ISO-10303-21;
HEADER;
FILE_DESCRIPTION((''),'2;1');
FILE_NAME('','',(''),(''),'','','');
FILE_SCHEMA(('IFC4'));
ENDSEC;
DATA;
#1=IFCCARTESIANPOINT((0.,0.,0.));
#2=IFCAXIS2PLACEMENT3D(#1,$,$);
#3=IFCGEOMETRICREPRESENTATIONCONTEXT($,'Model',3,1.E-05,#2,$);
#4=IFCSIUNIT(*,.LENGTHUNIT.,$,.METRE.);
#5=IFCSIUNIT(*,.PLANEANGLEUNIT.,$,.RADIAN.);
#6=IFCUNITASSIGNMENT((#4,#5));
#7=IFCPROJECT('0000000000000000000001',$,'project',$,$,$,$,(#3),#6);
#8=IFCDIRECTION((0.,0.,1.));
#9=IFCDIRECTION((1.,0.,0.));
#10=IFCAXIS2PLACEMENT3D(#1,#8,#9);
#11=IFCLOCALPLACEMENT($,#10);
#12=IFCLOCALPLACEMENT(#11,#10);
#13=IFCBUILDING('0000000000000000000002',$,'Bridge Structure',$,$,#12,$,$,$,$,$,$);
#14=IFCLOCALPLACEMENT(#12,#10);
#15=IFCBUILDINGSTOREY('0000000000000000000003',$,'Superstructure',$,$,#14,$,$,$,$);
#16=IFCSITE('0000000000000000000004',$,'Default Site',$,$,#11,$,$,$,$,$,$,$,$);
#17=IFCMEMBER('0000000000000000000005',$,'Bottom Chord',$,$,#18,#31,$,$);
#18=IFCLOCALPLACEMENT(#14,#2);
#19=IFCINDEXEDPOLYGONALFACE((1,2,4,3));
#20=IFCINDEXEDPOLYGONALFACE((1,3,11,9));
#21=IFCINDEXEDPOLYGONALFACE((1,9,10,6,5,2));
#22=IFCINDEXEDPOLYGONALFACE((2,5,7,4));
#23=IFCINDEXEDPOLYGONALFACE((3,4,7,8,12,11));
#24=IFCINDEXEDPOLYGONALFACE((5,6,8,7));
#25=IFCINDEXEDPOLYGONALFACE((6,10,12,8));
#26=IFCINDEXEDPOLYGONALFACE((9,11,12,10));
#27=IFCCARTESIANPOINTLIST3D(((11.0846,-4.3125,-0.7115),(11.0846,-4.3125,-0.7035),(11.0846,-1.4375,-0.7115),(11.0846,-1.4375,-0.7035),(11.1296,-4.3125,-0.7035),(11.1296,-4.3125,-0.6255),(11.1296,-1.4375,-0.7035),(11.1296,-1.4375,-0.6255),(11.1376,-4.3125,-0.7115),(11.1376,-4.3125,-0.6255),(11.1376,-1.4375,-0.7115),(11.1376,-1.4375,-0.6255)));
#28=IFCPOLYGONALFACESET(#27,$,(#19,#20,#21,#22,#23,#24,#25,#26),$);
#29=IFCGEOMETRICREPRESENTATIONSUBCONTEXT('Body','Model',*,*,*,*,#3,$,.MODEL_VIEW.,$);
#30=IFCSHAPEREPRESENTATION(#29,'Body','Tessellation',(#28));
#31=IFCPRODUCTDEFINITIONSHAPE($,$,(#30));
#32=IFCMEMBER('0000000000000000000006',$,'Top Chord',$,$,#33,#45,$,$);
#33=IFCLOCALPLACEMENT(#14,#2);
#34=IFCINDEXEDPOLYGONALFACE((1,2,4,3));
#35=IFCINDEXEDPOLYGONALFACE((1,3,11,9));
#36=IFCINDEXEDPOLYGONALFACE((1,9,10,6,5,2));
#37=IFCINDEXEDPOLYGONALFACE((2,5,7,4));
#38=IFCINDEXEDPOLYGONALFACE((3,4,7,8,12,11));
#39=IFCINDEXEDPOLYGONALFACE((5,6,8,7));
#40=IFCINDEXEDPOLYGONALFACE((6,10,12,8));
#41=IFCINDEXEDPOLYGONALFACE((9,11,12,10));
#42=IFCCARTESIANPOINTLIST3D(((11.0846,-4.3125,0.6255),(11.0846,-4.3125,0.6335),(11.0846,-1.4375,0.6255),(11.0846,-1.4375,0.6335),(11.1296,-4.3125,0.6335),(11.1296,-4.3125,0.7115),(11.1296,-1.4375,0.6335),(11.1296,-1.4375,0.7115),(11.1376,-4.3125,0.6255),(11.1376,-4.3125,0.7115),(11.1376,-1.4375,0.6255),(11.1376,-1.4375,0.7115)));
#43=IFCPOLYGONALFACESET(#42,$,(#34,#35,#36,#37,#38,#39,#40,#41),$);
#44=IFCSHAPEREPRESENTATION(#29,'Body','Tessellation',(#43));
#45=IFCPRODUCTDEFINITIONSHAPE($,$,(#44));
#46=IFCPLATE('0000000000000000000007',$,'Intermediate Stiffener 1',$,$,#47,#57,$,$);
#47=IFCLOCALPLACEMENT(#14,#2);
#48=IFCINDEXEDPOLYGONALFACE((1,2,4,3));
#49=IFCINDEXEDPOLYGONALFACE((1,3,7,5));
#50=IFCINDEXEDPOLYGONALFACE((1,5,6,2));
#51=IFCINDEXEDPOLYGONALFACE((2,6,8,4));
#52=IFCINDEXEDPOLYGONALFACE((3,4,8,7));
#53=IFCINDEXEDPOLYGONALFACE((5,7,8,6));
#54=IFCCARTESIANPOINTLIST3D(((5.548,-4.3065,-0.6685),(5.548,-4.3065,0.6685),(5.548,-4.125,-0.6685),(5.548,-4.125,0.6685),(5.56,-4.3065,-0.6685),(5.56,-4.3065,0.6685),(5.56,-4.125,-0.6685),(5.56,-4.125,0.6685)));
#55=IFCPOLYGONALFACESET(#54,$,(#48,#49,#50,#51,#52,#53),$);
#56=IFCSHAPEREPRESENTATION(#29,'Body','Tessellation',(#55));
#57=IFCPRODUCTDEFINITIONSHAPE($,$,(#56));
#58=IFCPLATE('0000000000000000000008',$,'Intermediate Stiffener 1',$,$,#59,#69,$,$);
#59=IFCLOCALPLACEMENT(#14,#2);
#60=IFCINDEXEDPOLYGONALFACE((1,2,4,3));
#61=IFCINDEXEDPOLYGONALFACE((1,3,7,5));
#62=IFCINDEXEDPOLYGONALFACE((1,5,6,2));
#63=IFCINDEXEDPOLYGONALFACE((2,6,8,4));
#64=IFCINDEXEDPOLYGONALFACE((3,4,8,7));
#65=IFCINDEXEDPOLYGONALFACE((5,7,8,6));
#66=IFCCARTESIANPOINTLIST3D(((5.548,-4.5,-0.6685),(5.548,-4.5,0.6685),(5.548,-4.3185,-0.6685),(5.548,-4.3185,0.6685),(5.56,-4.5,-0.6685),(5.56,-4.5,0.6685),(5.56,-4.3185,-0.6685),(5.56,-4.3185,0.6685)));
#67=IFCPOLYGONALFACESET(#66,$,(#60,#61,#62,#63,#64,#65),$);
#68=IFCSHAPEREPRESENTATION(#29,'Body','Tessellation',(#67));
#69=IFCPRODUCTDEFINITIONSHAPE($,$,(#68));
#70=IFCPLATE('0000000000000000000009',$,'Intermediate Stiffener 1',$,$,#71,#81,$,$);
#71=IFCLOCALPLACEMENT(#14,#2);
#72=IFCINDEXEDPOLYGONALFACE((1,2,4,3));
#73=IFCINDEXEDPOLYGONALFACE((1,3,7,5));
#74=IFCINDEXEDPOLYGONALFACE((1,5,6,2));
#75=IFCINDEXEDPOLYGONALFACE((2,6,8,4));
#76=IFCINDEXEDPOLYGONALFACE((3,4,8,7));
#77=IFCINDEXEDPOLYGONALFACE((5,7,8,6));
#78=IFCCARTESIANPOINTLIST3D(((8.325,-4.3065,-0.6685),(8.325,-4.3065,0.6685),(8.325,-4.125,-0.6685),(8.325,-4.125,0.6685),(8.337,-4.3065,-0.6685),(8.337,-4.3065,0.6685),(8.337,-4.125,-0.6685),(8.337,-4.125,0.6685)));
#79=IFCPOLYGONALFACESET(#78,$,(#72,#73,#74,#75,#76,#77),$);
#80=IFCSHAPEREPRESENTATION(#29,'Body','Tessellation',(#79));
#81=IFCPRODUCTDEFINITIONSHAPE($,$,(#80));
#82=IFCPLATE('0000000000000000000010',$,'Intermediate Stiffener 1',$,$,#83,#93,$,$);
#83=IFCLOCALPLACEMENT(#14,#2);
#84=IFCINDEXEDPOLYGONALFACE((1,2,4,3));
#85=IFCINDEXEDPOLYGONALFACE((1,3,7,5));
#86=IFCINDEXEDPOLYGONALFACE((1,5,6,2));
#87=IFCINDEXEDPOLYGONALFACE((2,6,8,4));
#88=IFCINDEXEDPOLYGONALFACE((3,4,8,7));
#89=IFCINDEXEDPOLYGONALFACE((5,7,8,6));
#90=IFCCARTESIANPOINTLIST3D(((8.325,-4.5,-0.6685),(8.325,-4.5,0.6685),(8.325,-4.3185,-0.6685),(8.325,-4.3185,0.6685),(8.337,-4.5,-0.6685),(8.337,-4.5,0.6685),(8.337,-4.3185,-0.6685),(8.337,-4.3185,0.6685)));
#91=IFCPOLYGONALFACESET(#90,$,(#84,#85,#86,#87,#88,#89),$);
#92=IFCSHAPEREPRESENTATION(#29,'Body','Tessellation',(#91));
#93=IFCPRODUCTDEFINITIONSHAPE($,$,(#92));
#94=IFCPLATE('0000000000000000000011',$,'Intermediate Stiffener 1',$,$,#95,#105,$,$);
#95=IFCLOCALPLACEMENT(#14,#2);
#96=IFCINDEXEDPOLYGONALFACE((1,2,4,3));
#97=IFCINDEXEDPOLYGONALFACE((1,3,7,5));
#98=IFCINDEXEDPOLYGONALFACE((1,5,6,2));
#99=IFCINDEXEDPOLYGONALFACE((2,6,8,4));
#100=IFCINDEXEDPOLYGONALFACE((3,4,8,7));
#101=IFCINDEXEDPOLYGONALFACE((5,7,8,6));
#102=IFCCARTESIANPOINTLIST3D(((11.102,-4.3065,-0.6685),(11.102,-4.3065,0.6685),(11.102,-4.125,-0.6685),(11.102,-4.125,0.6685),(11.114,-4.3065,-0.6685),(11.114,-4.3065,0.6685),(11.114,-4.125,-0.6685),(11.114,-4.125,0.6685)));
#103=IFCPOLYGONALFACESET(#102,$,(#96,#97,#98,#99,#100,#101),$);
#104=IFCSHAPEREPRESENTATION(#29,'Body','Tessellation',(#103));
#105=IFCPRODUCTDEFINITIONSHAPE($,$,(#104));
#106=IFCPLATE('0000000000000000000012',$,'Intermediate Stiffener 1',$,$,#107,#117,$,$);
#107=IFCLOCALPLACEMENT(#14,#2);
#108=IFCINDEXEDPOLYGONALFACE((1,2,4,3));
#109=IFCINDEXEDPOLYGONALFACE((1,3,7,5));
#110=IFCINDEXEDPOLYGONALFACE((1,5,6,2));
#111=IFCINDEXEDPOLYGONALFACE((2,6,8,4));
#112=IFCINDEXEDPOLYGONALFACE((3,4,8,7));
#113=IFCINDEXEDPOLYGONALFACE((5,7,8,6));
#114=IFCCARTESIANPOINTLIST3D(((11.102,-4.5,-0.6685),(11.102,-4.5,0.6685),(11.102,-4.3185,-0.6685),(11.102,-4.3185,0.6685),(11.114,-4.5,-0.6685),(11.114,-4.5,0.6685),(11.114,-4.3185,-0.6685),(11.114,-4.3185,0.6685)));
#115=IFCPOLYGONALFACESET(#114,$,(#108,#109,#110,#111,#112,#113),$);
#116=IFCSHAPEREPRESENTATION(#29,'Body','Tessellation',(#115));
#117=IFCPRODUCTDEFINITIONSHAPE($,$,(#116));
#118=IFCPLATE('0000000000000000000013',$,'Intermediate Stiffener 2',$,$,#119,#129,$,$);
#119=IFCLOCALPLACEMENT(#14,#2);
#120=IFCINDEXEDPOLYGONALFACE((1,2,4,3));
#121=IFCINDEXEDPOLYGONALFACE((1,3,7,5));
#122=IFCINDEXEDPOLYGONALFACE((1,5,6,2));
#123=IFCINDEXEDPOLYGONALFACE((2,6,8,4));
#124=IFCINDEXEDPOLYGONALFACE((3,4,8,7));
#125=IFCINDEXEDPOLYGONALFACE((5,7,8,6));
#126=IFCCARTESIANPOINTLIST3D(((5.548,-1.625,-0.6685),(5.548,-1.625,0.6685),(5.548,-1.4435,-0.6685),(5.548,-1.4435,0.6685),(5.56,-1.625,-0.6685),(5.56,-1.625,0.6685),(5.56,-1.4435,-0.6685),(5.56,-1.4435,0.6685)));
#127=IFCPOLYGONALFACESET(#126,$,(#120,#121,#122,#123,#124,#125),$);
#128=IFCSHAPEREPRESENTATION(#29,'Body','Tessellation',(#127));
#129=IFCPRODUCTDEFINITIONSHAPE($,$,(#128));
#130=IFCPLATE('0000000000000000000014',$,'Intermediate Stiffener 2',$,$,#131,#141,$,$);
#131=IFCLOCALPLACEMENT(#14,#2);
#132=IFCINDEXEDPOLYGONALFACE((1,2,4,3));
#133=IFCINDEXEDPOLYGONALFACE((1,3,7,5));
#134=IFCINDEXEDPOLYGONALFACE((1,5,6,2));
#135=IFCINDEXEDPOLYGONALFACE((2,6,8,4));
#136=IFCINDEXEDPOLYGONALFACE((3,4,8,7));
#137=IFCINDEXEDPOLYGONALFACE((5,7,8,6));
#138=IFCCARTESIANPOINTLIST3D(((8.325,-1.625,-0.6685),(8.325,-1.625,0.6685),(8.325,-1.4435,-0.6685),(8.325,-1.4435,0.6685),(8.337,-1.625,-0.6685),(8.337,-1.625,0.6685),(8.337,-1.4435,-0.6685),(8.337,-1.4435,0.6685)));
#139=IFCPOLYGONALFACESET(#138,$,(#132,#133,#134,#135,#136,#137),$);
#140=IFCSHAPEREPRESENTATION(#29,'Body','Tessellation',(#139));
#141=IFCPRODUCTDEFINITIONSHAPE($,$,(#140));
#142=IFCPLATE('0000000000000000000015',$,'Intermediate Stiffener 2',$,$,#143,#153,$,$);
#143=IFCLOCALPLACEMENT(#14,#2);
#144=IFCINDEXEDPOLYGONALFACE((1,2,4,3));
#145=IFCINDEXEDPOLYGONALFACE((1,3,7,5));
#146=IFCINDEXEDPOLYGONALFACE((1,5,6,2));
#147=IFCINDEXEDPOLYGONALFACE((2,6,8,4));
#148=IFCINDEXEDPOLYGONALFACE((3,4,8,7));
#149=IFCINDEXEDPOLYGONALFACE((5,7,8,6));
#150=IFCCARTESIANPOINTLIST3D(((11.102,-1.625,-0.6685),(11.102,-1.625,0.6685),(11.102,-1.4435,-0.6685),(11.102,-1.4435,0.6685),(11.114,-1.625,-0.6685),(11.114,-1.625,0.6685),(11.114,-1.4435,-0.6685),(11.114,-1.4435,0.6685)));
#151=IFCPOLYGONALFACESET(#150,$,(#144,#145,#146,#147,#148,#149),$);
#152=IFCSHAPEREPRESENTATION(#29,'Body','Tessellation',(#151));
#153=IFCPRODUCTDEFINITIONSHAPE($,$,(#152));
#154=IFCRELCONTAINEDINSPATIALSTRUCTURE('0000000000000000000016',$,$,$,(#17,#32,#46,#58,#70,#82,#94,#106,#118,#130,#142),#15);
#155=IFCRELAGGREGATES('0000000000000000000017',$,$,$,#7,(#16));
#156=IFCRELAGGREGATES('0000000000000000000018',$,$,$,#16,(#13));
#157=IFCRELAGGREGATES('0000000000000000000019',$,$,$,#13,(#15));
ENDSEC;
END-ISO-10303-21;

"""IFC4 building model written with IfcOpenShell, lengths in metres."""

from ifc_helpers import new_model, si_unit, frame, origin, origin_with_axes, origin_2d_with_axis, place, context, subcontext, project, spatial, rectangle, l_section, extrude, element, save


model = new_model("IFC4")

# Units and contexts
model_context = context("Model", 3, precision=1e-05, world=origin())
body_context = subcontext(model_context, "Body", "Model", "MODEL_VIEW")
ifc_project = project(units=[si_unit("LENGTHUNIT", "METRE"), si_unit("PLANEANGLEUNIT", "RADIAN")], contexts=[model_context])

# Site, building, storey
site_placement = place(None, origin_with_axes())
site = spatial("IfcSite", under=ifc_project, at=site_placement, Name="Default Site")
building_placement = place(site_placement, origin_with_axes())
building = spatial("IfcBuilding", under=site, at=building_placement, Name="Bridge Structure")
storey_placement = place(building_placement, origin_with_axes())
storey = spatial("IfcBuildingStorey", under=building, at=storey_placement, Name="Superstructure")

# Members
for number, where, z_axis, x_axis, name in (
    (1, (11.1111, -4.3125, -0.6685), (0.0, 1.0, 0.0), (-1.0, 0.0, 0.0), "Bottom Chord"),
    (2, (11.1111, -4.3125, 0.6685), (0.0, 1.0, 0.0), (-1.0, 0.0, 0.0), "Top Chord"),
):
    element("IfcMember", number, at=place(storey_placement, frame(where, z_axis=z_axis, x_axis=x_axis)), inside=storey, Name=name, context=body_context, shape_type="SweptSolid", body=[
        extrude(l_section(Depth=0.086, Width=0.053, Thickness=0.008, at=origin_2d_with_axis()), origin_with_axes(), (0.0, 0.0, 1.0), 2.875),
    ])

# Plates
for number, where, z_axis, x_axis, name in (
    (3, (5.554, -4.2157, -0.6685), (0.0, 0.0, 1.0), (1.0, 0.0, 0.0), "Intermediate Stiffener 1"),
    (4, (5.554, -4.4093, -0.6685), (0.0, 0.0, 1.0), (1.0, 0.0, 0.0), "Intermediate Stiffener 1"),
    (5, (8.331, -4.2157, -0.6685), (0.0, 0.0, 1.0), (1.0, 0.0, 0.0), "Intermediate Stiffener 1"),
    (6, (8.331, -4.4093, -0.6685), (0.0, 0.0, 1.0), (1.0, 0.0, 0.0), "Intermediate Stiffener 1"),
    (7, (11.108, -4.2157, -0.6685), (0.0, 0.0, 1.0), (1.0, 0.0, 0.0), "Intermediate Stiffener 1"),
    (8, (11.108, -4.4093, -0.6685), (0.0, 0.0, 1.0), (1.0, 0.0, 0.0), "Intermediate Stiffener 1"),
    (9, (5.554, -1.5343, -0.6685), (0.0, 0.0, 1.0), (1.0, 0.0, 0.0), "Intermediate Stiffener 2"),
    (10, (8.331, -1.5343, -0.6685), (0.0, 0.0, 1.0), (1.0, 0.0, 0.0), "Intermediate Stiffener 2"),
    (11, (11.108, -1.5343, -0.6685), (0.0, 0.0, 1.0), (1.0, 0.0, 0.0), "Intermediate Stiffener 2"),
):
    element("IfcPlate", number, at=place(storey_placement, frame(where, z_axis=z_axis, x_axis=x_axis)), inside=storey, Name=name, context=body_context, shape_type="SweptSolid", body=[
        extrude(rectangle(XDim=0.012, YDim=0.1815, at=origin_2d_with_axis()), origin_with_axes(), (0.0, 0.0, 1.0), 1.337),
    ])

save(model, "model.ifc")
